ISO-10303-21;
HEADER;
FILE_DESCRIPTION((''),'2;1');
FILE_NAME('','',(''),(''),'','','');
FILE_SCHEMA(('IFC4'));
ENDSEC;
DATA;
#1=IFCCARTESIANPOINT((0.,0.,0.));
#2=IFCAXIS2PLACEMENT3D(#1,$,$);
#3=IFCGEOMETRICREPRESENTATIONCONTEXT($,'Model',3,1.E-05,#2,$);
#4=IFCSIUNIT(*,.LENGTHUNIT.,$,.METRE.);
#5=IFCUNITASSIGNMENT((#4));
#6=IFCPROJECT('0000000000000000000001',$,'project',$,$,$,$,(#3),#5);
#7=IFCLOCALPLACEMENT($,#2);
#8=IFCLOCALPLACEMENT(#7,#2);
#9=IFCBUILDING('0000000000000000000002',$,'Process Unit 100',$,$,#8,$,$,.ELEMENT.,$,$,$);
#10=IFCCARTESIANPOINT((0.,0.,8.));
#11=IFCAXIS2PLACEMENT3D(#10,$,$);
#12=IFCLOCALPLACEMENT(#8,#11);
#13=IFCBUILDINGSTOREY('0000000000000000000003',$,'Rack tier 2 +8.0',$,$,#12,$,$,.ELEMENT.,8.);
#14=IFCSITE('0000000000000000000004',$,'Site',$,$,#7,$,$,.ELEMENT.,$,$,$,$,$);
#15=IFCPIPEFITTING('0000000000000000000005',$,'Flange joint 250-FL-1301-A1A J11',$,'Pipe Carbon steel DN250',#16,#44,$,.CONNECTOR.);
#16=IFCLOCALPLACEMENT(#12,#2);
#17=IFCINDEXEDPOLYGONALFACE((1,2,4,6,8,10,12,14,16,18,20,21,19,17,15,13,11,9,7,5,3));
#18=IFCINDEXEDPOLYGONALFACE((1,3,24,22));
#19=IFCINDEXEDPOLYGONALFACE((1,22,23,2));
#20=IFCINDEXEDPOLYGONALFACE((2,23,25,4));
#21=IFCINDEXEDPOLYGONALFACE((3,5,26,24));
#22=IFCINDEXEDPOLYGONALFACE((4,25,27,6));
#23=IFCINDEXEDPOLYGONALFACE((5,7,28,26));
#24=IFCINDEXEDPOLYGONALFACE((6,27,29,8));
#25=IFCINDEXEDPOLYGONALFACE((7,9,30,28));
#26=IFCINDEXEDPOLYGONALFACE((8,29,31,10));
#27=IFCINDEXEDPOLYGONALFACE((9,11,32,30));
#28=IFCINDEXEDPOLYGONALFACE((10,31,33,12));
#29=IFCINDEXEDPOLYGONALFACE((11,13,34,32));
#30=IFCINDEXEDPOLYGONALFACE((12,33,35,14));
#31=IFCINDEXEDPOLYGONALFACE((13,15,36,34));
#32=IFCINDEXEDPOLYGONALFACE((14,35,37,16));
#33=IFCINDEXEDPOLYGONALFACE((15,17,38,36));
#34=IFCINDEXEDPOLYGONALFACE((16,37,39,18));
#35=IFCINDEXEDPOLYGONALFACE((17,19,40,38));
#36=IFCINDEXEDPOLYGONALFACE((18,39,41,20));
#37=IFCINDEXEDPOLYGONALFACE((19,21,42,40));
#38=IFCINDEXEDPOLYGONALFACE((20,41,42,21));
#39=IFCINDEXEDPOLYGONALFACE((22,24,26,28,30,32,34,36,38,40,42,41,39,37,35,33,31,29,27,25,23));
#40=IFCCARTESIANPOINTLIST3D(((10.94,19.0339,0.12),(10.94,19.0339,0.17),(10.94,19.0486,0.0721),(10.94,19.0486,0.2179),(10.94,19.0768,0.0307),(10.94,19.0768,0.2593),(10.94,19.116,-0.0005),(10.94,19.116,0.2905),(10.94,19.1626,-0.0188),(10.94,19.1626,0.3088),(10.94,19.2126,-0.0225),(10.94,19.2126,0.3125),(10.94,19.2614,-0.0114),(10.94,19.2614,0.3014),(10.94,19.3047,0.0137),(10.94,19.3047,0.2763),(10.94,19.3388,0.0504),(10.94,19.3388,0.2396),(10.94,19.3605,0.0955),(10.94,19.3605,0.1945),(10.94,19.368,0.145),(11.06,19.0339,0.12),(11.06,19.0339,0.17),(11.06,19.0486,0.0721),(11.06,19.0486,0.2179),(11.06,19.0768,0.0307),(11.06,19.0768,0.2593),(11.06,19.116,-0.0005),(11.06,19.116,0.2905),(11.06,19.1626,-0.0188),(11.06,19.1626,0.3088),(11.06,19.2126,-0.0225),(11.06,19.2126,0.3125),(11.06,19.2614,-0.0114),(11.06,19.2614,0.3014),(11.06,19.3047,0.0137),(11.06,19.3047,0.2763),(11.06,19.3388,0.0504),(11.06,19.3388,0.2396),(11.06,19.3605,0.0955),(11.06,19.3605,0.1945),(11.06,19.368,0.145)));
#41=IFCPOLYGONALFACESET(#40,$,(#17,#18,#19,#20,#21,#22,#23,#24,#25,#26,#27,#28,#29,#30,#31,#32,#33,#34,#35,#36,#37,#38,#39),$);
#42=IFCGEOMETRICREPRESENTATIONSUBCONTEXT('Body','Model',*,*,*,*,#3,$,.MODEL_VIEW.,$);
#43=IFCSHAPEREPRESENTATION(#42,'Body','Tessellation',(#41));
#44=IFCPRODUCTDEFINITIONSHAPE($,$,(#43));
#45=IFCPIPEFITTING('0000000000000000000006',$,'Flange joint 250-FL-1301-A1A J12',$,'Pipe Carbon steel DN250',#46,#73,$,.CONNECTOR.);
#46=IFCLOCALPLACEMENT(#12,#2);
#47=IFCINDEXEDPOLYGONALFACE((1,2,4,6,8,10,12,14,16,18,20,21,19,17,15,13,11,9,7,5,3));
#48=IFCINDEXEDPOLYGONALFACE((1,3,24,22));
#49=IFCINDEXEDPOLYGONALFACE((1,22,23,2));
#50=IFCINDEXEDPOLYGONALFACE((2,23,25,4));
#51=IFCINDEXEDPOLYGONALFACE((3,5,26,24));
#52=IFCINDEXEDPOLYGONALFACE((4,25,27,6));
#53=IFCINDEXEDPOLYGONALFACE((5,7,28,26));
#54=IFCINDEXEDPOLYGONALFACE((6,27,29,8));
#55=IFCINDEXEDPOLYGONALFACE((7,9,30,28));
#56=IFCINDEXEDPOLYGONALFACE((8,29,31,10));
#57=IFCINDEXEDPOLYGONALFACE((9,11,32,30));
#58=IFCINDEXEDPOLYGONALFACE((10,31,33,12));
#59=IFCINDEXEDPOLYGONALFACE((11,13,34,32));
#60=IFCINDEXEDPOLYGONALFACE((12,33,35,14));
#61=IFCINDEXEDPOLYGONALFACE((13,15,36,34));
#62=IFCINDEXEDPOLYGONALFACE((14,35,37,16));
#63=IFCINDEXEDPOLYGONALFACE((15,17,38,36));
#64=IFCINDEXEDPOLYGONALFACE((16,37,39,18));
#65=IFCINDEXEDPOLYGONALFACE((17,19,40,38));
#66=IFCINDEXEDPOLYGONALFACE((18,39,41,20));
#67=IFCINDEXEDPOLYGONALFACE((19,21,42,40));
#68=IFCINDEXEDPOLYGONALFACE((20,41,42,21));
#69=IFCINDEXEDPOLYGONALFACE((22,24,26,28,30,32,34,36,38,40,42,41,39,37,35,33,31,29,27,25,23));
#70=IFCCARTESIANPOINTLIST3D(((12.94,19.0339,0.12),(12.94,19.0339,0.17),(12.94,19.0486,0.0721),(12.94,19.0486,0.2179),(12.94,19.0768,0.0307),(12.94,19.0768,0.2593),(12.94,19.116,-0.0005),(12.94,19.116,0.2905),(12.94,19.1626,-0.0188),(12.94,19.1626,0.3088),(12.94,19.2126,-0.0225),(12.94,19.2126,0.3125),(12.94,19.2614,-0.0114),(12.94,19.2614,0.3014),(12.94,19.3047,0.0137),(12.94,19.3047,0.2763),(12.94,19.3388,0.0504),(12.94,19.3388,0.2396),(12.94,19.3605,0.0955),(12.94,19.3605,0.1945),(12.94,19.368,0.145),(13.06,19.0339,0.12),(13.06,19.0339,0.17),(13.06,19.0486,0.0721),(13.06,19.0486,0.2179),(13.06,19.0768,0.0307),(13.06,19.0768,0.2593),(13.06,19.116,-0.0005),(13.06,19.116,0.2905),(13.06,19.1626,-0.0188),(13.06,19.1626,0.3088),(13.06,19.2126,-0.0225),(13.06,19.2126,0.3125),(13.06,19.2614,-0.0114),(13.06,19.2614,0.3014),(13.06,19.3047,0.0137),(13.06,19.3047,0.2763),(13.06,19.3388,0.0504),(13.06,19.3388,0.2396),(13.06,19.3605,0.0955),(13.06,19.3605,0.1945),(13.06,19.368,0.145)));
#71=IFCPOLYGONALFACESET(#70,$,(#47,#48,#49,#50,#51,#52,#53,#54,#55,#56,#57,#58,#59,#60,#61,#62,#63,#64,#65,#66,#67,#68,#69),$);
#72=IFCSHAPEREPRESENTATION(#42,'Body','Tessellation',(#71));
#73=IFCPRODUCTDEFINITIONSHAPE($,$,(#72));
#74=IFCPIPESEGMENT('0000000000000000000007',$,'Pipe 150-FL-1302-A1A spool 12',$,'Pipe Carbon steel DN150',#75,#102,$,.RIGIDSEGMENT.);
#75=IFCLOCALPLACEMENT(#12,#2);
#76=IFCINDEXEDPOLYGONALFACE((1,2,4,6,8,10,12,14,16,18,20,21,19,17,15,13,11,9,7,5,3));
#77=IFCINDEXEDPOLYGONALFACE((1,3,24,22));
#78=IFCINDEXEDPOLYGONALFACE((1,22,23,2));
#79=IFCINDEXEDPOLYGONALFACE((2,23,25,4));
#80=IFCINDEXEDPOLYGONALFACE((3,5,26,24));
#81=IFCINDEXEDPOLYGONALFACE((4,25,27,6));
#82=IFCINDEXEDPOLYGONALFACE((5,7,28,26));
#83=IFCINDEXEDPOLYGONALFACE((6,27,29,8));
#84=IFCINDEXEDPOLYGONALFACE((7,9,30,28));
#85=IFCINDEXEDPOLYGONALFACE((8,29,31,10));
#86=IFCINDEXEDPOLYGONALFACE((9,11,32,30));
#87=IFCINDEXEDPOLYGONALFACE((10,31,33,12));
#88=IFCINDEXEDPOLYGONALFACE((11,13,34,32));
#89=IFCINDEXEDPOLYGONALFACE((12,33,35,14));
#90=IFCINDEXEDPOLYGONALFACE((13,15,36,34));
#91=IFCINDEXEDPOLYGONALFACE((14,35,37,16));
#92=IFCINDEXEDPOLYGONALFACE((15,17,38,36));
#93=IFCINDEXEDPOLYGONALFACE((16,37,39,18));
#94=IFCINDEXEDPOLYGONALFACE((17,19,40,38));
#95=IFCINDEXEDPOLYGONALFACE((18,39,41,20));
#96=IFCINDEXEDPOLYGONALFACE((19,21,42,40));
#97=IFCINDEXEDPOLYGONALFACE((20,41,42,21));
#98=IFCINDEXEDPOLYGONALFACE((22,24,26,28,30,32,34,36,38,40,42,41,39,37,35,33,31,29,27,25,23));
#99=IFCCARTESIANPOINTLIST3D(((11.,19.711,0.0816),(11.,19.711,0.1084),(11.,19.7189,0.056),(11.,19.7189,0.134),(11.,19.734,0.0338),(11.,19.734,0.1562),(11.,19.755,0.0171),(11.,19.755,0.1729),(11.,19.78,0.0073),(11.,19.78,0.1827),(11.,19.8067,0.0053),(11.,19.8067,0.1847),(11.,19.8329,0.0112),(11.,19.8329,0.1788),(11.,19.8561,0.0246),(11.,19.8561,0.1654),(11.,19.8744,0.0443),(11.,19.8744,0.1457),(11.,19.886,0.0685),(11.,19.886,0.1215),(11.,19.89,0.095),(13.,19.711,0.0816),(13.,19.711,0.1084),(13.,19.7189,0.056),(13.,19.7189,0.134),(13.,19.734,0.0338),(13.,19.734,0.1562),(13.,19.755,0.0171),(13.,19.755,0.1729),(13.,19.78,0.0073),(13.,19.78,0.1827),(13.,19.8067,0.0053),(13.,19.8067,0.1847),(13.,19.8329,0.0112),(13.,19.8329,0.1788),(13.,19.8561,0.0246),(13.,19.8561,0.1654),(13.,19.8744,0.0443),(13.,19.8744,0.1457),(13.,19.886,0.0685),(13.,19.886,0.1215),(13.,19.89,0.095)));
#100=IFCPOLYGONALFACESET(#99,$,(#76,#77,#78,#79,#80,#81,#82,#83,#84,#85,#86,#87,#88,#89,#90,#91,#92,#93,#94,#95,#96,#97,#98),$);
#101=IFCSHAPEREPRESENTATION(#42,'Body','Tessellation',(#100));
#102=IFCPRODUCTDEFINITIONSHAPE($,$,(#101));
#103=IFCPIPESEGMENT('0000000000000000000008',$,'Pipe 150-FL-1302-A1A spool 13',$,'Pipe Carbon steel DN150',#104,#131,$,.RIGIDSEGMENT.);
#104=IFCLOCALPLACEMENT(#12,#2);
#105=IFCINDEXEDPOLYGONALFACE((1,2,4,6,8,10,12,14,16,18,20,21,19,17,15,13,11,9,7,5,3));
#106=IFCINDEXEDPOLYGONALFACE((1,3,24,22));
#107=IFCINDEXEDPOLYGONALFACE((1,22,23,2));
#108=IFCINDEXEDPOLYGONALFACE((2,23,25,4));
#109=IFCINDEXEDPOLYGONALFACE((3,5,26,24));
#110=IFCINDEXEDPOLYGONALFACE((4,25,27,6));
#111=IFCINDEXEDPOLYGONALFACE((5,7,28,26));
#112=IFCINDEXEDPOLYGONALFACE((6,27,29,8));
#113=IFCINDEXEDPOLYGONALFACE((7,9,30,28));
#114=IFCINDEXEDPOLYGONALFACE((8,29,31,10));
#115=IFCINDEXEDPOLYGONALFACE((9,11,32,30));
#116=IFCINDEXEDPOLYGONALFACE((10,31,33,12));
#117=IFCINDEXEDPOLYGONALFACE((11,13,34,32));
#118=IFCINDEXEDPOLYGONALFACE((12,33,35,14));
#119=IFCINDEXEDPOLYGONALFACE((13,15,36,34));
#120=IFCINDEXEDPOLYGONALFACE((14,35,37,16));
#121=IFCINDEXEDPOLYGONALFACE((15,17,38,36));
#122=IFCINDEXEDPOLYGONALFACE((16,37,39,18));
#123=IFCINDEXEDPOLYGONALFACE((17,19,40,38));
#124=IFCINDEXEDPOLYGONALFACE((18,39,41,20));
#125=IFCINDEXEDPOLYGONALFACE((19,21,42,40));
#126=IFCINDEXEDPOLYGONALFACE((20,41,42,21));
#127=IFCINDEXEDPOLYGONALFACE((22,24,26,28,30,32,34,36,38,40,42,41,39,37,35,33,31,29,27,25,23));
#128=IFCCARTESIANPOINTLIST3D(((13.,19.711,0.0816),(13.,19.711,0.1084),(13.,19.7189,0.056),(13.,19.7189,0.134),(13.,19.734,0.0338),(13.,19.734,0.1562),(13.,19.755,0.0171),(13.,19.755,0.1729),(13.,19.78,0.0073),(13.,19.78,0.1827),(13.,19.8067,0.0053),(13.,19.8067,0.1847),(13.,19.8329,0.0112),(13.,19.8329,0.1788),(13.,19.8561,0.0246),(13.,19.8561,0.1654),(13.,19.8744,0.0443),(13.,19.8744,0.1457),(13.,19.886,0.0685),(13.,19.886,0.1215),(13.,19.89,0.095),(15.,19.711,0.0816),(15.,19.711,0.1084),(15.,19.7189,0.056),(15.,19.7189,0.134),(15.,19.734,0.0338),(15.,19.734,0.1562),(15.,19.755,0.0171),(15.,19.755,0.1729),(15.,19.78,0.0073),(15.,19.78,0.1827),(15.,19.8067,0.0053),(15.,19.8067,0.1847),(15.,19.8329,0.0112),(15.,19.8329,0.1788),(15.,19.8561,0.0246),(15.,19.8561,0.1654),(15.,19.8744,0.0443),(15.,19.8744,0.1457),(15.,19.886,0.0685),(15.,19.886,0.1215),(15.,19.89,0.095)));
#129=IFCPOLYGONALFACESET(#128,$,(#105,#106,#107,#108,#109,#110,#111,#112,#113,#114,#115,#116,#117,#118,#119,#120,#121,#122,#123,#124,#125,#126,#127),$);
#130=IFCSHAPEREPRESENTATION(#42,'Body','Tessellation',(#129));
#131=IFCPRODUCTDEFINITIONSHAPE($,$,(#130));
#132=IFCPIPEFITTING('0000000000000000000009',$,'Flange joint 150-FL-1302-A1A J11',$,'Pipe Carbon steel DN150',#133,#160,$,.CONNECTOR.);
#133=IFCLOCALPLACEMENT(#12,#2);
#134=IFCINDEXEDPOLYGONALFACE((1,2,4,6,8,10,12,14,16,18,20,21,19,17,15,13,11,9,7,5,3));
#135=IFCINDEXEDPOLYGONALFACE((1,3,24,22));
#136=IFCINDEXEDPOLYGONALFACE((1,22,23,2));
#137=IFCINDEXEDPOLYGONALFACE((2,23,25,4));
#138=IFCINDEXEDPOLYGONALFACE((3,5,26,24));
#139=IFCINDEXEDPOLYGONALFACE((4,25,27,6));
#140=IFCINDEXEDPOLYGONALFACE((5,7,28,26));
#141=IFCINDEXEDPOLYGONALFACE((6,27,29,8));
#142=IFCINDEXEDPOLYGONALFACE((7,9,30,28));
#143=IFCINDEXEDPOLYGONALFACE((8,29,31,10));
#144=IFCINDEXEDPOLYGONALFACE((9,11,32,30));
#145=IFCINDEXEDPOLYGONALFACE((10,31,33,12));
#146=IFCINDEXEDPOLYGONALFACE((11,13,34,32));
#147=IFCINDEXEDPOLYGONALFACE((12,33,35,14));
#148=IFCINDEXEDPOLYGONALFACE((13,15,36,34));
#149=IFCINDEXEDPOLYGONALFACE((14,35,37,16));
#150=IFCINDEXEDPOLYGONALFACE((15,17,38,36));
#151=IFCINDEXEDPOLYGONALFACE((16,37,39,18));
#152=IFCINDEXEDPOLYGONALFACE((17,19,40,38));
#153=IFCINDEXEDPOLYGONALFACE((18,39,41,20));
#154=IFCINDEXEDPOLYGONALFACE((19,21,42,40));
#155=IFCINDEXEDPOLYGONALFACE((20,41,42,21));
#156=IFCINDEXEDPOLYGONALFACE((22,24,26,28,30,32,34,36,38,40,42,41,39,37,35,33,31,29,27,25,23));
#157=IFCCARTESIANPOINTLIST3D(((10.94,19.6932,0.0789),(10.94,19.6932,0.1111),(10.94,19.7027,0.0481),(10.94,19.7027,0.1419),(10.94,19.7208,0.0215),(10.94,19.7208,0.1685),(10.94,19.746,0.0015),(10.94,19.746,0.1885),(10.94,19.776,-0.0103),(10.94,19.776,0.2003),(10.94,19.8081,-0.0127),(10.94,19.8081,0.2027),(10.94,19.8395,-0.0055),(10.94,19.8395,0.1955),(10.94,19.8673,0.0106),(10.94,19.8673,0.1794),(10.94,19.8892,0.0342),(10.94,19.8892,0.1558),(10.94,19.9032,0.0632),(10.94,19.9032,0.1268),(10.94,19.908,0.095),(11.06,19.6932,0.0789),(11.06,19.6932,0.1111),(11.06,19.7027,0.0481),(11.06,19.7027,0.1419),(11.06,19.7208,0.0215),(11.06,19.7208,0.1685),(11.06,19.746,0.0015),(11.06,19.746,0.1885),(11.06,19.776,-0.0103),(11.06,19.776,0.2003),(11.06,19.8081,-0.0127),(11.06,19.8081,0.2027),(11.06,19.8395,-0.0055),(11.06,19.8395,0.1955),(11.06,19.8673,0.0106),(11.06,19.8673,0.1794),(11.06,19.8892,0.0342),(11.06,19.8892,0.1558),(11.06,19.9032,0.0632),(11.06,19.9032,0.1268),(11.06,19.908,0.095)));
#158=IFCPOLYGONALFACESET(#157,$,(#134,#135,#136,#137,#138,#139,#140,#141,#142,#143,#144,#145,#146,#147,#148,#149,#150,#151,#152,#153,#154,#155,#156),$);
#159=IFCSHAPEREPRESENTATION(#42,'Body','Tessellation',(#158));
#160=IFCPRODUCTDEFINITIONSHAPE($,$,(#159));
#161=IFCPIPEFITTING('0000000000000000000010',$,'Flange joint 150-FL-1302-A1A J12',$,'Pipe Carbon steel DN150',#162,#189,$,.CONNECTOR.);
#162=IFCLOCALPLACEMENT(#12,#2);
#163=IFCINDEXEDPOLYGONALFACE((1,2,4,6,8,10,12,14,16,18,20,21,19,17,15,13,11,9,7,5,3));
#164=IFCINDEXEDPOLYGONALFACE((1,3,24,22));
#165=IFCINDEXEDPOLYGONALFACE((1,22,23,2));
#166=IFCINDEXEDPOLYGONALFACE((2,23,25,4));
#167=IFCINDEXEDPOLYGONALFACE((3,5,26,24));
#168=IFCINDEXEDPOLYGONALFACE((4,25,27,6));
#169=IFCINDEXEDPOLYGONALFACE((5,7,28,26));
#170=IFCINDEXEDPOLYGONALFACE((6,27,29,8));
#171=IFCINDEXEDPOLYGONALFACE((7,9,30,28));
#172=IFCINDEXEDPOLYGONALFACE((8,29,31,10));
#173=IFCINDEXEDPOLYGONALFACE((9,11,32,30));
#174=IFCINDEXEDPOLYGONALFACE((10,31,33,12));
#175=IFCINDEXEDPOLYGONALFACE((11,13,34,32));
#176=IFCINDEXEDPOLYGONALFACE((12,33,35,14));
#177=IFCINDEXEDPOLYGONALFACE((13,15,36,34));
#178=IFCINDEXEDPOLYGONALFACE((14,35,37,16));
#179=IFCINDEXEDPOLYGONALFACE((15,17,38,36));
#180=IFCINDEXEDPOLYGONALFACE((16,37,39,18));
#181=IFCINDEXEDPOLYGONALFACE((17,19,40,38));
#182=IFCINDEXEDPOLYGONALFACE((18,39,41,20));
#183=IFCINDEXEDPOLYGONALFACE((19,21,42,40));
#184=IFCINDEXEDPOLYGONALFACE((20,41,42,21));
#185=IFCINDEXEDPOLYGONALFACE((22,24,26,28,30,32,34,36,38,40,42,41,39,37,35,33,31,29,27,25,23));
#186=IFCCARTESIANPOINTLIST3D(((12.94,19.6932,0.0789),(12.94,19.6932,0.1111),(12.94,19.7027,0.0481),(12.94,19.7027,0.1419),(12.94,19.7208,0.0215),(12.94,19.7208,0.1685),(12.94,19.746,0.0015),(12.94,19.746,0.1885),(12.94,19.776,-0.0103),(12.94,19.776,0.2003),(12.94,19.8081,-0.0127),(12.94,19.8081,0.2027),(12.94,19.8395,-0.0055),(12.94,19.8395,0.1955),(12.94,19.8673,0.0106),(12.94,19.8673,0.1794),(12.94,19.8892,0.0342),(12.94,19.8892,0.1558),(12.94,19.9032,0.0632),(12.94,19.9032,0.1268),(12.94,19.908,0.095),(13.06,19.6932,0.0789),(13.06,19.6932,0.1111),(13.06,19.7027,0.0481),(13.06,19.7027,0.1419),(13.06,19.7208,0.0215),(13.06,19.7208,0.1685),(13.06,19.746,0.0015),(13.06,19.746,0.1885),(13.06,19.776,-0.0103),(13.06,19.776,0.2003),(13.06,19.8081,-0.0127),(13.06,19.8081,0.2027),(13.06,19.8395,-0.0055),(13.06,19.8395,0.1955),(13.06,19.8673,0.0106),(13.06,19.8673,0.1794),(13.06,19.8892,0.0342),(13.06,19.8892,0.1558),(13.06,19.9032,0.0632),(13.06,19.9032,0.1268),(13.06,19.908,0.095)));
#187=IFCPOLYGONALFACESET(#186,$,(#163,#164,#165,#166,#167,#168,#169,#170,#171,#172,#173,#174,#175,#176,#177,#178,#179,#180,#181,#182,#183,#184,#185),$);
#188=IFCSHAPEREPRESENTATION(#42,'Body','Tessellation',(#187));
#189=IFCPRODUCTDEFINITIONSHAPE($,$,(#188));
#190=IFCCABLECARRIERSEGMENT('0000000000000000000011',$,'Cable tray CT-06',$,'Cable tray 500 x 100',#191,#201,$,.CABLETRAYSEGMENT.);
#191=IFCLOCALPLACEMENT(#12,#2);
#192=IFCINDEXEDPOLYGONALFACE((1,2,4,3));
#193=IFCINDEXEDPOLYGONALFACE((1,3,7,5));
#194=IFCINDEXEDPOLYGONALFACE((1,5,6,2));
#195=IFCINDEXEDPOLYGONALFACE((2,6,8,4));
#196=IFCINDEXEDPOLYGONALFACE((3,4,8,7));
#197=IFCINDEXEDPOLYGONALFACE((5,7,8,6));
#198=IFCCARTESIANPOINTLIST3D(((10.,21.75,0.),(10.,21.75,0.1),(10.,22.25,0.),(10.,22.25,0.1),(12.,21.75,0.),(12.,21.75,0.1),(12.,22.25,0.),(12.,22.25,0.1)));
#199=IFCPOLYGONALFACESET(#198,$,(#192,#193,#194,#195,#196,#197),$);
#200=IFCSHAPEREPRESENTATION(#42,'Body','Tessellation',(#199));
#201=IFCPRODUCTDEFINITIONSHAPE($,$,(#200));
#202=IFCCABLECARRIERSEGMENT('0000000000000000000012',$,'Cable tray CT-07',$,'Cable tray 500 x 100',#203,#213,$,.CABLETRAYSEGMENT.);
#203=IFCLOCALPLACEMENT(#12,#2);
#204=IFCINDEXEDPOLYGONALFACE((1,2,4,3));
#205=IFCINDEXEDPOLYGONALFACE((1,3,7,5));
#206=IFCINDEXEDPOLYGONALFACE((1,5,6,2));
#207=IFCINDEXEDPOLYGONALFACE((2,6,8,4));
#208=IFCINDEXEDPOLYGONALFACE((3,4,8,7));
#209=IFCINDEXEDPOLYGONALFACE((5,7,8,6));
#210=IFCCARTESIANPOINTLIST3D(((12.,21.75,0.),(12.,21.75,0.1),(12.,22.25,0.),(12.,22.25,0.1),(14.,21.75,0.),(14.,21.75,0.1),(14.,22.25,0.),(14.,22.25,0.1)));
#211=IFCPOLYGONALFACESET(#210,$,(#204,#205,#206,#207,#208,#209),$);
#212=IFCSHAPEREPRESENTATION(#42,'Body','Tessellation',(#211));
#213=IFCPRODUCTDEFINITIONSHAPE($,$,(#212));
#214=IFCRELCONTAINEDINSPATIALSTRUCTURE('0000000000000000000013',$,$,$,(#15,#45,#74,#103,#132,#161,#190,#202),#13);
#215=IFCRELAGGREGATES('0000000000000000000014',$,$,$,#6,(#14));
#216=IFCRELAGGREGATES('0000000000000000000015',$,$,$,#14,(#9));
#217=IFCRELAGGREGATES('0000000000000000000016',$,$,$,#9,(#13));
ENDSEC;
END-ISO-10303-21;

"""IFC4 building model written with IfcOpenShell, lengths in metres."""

from ifc_helpers import new_model, si_unit, frame, origin, place, context, subcontext, project, spatial, rectangle, circle, extrude, element, save


model = new_model("IFC4")

# Units and contexts
model_context = context("Model", 3, precision=1e-05, world=origin())
body_context = subcontext(model_context, "Body", "Model", "MODEL_VIEW")
ifc_project = project(units=[si_unit("LENGTHUNIT", "METRE")], contexts=[model_context])

# Site, building, storey
site_placement = place(None, origin())
site = spatial("IfcSite", under=ifc_project, at=site_placement, Name="Site", CompositionType="ELEMENT")
building_placement = place(site_placement, origin())
building = spatial("IfcBuilding", under=site, at=building_placement, Name="Process Unit 100", CompositionType="ELEMENT")
storey_placement = place(building_placement, frame((0.0, 0.0, 8.0)))
storey = spatial("IfcBuildingStorey", under=building, at=storey_placement, Name="Rack tier 2 +8.0", CompositionType="ELEMENT", Elevation=8.0)

# Pipe fittings
for number, where, z_axis, x_axis, name in (
    (1, (10.94, 19.2, 0.145), (1.0, 0.0, 0.0), (0.0, 1.0, 0.0), "Flange joint 250-FL-1301-A1A J11"),
    (2, (12.94, 19.2, 0.145), (1.0, 0.0, 0.0), (0.0, 1.0, 0.0), "Flange joint 250-FL-1301-A1A J12"),
):
    element("IfcPipeFitting", number, at=place(storey_placement, frame(where, z_axis=z_axis, x_axis=x_axis)), inside=storey, Name=name, ObjectType="Pipe Carbon steel DN250", PredefinedType="CONNECTOR", context=body_context, shape_type="SweptSolid", body=[
        extrude(circle(Radius=0.168), origin(), (0.0, 0.0, 1.0), 0.12),
    ])

# Pipe segments
for number, where, z_axis, x_axis, name in (
    (3, (11.0, 19.8, 0.095), (1.0, 0.0, 0.0), (0.0, 1.0, 0.0), "Pipe 150-FL-1302-A1A spool 12"),
    (4, (13.0, 19.8, 0.095), (1.0, 0.0, 0.0), (0.0, 1.0, 0.0), "Pipe 150-FL-1302-A1A spool 13"),
):
    element("IfcPipeSegment", number, at=place(storey_placement, frame(where, z_axis=z_axis, x_axis=x_axis)), inside=storey, Name=name, ObjectType="Pipe Carbon steel DN150", PredefinedType="RIGIDSEGMENT", context=body_context, shape_type="SweptSolid", body=[
        extrude(circle(Radius=0.09), origin(), (0.0, 0.0, 1.0), 2.0),
    ])

# Pipe fittings
for number, where, z_axis, x_axis, name in (
    (5, (10.94, 19.8, 0.095), (1.0, 0.0, 0.0), (0.0, 1.0, 0.0), "Flange joint 150-FL-1302-A1A J11"),
    (6, (12.94, 19.8, 0.095), (1.0, 0.0, 0.0), (0.0, 1.0, 0.0), "Flange joint 150-FL-1302-A1A J12"),
):
    element("IfcPipeFitting", number, at=place(storey_placement, frame(where, z_axis=z_axis, x_axis=x_axis)), inside=storey, Name=name, ObjectType="Pipe Carbon steel DN150", PredefinedType="CONNECTOR", context=body_context, shape_type="SweptSolid", body=[
        extrude(circle(Radius=0.108), origin(), (0.0, 0.0, 1.0), 0.12),
    ])

# Cable carrier segments
for number, where, z_axis, x_axis, name in (
    (7, (10.0, 22.0, 0.05), (1.0, 0.0, 0.0), (0.0, 1.0, 0.0), "Cable tray CT-06"),
    (8, (12.0, 22.0, 0.05), (1.0, 0.0, 0.0), (0.0, 1.0, 0.0), "Cable tray CT-07"),
):
    element("IfcCableCarrierSegment", number, at=place(storey_placement, frame(where, z_axis=z_axis, x_axis=x_axis)), inside=storey, Name=name, ObjectType="Cable tray 500 x 100", PredefinedType="CABLETRAYSEGMENT", context=body_context, shape_type="SweptSolid", body=[
        extrude(rectangle(XDim=0.5, YDim=0.1), origin(), (0.0, 0.0, 1.0), 2.0),
    ])

save(model, "model.ifc")
